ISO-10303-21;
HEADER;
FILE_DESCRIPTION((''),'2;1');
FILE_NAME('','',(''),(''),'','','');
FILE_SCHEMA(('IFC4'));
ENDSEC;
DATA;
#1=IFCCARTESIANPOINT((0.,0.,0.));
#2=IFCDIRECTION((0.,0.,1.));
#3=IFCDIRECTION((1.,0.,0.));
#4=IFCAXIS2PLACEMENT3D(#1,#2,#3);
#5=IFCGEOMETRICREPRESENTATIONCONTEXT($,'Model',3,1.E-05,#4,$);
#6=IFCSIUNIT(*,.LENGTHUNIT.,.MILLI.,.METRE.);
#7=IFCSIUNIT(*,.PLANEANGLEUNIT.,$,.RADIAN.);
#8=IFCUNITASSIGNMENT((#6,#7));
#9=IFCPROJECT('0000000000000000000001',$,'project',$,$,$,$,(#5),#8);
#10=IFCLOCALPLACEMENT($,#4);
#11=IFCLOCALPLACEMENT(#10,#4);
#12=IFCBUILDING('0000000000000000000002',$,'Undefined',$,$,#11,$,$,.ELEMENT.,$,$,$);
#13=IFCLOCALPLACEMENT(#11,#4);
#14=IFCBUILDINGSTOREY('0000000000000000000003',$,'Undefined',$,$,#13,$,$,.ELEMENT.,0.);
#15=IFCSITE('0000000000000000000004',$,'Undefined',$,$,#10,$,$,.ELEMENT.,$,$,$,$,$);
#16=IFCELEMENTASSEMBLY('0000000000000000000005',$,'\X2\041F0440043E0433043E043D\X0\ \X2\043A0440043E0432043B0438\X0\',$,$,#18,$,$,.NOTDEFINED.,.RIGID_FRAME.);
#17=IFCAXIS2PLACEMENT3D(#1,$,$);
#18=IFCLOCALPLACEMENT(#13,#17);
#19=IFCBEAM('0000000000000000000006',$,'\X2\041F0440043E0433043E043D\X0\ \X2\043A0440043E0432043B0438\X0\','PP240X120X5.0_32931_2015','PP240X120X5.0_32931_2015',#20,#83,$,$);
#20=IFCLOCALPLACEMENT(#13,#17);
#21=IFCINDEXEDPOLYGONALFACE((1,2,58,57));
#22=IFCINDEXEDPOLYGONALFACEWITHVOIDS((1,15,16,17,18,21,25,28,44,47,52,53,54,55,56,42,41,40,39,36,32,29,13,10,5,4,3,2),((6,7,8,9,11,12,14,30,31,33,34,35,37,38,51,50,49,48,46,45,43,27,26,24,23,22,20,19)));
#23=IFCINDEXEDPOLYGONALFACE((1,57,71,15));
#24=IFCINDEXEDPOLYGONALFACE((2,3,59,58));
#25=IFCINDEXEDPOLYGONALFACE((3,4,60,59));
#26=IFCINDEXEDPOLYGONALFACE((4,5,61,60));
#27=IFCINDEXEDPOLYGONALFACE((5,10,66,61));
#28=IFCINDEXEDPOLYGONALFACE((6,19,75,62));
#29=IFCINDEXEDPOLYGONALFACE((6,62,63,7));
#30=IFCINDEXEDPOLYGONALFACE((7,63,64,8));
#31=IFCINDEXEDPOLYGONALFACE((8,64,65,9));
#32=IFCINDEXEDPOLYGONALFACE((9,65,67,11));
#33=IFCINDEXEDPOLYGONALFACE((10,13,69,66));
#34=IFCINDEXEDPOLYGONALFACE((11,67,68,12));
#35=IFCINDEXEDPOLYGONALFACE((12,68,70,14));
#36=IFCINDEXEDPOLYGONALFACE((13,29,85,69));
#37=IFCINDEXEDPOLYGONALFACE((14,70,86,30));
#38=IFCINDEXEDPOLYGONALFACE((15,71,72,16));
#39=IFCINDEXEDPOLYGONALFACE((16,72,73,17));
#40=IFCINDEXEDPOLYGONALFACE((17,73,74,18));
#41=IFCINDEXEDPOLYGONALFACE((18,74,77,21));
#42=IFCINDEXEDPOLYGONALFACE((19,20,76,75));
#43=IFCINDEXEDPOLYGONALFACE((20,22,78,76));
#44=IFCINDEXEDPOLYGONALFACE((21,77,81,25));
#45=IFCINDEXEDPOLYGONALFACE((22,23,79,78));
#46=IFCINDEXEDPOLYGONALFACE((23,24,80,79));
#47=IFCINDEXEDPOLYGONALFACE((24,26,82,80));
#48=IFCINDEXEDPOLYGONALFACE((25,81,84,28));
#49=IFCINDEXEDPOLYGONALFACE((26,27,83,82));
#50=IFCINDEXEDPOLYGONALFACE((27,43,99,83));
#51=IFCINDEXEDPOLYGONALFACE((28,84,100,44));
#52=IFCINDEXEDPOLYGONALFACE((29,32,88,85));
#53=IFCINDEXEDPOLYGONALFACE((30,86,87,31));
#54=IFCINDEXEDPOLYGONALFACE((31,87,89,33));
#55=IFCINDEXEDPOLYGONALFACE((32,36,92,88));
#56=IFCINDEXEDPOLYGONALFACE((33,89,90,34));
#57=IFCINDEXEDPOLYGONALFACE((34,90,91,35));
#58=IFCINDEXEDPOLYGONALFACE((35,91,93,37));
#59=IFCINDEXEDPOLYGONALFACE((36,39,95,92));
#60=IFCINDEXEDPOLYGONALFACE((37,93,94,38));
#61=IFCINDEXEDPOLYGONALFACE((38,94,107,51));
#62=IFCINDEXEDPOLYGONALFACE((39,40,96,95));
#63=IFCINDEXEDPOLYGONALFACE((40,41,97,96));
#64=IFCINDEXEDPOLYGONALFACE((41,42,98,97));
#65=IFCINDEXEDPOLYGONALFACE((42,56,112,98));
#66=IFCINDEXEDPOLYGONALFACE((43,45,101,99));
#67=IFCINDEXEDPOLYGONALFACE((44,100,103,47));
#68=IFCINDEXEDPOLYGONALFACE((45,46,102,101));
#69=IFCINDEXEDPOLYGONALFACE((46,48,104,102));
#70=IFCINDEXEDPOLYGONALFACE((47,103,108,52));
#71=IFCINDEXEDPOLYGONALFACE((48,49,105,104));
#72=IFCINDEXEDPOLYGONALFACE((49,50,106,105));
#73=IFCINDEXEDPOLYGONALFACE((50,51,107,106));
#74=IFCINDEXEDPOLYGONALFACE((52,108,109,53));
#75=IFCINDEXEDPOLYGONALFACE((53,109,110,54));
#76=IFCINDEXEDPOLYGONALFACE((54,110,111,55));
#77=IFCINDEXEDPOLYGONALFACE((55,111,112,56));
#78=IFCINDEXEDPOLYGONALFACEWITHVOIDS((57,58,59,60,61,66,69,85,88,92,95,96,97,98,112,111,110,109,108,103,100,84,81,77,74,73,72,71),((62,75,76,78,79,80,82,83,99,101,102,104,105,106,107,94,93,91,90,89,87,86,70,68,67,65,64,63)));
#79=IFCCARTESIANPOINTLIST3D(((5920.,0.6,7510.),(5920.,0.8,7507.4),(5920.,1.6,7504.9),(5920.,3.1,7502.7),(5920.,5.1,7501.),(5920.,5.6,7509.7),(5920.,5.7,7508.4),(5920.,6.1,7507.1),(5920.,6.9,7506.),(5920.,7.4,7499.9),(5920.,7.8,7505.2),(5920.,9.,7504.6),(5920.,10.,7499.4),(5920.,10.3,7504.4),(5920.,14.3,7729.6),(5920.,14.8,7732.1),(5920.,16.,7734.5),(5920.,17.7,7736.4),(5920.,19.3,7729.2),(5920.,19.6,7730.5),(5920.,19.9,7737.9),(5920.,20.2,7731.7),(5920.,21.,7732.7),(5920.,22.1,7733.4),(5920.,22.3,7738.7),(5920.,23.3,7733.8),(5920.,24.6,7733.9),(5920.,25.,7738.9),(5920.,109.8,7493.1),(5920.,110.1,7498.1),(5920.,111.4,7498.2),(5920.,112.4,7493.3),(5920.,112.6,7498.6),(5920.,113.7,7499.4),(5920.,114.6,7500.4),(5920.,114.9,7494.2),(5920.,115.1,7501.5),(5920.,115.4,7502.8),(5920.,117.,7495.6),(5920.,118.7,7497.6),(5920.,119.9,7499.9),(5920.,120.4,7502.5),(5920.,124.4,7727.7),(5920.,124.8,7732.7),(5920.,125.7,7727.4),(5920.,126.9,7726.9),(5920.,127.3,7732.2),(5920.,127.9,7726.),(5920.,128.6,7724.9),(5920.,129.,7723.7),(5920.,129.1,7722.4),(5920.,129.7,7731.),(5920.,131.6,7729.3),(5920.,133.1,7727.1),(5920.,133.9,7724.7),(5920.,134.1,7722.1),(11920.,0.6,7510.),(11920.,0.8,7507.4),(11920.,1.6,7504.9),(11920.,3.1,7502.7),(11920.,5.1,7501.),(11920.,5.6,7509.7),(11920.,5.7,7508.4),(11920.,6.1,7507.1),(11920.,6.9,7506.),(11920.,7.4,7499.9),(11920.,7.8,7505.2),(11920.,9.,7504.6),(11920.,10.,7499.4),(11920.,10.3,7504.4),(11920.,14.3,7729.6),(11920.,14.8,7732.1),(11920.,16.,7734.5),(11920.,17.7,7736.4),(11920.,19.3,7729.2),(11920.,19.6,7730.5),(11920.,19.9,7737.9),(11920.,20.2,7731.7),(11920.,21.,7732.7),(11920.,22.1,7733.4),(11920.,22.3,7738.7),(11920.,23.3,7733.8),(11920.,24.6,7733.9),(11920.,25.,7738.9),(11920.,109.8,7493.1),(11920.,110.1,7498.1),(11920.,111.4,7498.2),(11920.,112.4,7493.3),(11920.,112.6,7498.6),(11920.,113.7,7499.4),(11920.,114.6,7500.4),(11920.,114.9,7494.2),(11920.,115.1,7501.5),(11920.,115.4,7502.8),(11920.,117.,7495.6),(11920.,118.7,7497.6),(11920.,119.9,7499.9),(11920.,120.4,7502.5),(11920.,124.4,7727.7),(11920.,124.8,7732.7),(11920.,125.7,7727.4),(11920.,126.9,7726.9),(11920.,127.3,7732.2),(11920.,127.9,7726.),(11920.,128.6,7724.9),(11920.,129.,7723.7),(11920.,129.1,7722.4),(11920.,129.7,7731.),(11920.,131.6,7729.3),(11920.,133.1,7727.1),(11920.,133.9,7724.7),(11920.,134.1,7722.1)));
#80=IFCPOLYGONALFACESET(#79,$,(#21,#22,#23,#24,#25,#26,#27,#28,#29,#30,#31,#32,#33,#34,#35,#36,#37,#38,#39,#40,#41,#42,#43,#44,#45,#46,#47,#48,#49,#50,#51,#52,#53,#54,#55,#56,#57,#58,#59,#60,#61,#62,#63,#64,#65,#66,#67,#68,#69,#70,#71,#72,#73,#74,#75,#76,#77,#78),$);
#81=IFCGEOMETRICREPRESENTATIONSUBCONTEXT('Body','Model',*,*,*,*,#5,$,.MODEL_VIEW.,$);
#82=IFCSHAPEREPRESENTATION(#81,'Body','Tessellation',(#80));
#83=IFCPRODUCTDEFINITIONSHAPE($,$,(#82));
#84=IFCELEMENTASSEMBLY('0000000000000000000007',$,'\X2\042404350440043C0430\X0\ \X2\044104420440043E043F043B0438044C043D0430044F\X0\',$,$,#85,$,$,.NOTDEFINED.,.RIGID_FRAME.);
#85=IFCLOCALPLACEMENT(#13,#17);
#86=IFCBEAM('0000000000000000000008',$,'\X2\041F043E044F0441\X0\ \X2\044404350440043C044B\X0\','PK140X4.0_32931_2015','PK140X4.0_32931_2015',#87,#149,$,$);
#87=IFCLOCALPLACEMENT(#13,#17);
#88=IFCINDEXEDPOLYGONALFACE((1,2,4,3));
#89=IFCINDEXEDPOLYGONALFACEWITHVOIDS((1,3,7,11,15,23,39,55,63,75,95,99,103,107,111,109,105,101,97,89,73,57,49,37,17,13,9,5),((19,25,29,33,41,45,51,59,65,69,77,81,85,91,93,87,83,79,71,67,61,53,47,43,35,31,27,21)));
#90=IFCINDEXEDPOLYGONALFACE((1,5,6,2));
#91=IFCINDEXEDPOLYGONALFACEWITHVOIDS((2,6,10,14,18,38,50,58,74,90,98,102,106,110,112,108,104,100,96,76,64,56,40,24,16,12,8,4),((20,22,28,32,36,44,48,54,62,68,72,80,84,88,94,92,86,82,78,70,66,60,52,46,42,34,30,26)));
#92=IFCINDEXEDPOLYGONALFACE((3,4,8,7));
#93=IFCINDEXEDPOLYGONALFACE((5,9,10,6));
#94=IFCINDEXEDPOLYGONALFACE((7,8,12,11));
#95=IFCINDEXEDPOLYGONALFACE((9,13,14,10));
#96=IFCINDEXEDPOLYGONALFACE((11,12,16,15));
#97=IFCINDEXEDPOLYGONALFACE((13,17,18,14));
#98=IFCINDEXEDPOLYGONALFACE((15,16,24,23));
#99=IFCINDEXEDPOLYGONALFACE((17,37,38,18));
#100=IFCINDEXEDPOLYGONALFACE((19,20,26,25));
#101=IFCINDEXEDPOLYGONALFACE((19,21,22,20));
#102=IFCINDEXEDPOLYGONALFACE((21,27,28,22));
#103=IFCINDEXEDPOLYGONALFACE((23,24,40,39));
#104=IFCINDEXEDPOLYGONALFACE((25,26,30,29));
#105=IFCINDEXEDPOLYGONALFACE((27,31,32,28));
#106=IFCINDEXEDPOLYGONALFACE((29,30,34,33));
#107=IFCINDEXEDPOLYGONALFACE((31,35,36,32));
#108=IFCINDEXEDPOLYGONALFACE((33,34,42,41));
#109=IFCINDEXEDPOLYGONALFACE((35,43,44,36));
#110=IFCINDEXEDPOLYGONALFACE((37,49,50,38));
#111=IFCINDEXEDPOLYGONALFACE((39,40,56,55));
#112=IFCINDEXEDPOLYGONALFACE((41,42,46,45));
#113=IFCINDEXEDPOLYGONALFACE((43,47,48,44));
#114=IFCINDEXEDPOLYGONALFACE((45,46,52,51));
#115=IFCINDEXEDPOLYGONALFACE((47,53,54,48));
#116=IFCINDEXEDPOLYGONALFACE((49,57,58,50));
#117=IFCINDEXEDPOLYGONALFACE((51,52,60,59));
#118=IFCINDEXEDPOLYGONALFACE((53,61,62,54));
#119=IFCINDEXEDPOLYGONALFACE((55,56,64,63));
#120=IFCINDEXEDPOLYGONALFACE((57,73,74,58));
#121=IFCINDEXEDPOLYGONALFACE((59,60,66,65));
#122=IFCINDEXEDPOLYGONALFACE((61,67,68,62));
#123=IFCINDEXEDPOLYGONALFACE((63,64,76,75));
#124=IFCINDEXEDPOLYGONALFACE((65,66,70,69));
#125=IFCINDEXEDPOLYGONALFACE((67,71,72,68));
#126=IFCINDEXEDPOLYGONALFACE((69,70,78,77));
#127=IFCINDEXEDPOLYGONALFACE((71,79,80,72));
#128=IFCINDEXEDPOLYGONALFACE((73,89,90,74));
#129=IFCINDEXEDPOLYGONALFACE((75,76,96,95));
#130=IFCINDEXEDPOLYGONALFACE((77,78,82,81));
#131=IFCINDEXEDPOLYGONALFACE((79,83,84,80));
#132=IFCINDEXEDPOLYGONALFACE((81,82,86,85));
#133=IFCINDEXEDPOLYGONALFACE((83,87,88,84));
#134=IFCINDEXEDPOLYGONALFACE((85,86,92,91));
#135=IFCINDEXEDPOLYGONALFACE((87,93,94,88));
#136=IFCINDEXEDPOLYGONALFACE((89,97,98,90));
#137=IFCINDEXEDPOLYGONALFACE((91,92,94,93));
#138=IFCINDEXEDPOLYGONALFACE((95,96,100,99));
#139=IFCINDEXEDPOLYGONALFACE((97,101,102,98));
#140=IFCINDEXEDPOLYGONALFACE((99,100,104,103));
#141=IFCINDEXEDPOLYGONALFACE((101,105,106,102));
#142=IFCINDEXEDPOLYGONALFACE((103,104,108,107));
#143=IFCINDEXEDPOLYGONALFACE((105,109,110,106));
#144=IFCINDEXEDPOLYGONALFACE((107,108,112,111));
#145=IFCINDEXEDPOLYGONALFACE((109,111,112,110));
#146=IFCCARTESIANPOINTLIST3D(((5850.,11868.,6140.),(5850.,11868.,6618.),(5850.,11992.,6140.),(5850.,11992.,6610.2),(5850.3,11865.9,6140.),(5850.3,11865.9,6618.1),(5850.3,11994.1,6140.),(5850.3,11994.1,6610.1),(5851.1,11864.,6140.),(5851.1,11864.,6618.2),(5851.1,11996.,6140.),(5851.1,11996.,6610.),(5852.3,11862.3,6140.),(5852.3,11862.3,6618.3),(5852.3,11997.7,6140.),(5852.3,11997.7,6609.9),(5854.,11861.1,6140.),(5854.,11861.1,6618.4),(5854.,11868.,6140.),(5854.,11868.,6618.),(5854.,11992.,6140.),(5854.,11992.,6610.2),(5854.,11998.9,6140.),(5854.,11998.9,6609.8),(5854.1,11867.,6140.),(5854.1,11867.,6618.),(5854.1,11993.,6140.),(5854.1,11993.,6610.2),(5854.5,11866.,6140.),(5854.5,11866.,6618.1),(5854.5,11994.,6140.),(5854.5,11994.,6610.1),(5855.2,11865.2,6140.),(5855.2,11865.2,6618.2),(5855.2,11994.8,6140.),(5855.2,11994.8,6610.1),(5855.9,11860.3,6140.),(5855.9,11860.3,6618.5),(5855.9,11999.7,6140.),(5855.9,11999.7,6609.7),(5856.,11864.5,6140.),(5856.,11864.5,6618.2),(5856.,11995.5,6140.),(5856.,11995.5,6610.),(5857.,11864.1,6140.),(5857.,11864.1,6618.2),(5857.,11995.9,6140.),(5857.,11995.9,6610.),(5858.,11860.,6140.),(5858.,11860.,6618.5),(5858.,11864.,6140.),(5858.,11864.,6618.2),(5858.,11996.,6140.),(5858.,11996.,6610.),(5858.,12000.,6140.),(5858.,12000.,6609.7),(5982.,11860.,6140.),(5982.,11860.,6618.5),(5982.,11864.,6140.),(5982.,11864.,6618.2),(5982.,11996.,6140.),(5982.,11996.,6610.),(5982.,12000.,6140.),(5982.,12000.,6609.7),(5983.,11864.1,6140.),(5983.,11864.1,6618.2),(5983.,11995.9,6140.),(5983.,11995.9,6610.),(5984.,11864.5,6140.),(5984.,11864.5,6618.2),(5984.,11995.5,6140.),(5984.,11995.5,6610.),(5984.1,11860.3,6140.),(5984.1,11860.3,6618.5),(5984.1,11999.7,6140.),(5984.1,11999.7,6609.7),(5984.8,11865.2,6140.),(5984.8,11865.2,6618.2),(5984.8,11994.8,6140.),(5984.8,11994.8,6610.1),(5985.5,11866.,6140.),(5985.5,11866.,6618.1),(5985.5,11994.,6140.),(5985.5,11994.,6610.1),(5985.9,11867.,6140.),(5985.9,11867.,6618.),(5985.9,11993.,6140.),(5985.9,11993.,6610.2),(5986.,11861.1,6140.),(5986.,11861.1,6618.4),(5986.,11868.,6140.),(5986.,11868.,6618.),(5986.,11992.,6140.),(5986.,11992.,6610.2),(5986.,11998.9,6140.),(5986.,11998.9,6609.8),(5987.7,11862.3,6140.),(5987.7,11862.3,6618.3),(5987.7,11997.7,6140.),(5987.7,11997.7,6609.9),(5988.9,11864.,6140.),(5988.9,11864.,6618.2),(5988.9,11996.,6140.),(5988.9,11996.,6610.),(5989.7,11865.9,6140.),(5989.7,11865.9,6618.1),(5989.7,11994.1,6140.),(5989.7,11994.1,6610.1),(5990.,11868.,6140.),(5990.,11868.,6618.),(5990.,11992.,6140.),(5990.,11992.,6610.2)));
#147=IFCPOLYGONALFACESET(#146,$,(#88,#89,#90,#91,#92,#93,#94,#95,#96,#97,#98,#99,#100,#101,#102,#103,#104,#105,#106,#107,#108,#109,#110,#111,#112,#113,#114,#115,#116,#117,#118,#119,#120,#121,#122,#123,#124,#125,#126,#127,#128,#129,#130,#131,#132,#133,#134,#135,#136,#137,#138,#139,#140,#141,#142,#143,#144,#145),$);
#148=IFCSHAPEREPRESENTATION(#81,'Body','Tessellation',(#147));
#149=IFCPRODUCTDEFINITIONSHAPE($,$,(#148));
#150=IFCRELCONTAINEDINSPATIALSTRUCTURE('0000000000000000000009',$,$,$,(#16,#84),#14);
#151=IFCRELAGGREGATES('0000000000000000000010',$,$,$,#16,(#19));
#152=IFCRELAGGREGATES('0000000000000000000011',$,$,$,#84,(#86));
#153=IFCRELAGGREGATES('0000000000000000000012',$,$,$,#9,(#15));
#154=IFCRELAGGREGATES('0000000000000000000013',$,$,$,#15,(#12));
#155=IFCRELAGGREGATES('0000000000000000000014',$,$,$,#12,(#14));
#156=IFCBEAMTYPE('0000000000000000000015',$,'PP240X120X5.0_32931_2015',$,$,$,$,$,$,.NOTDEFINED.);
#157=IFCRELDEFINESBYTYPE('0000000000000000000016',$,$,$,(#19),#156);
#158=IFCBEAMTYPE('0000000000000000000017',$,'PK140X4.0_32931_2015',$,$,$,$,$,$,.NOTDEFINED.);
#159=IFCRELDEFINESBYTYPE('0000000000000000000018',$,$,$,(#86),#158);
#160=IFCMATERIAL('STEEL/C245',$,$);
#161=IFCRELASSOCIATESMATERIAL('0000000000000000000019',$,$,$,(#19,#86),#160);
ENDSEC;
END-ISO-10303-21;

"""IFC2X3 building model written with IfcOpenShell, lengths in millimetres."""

from ifc_helpers import new_model, si_unit, frame, origin_with_axes, origin_2d_with_axis, place, context, subcontext, project, spatial, hollow_rectangle, extrude, clip, halfspace, material, type_object, element, aggregate, save


model = new_model("IFC2X3")

# Units and contexts
model_context = context("Model", 3, precision=1e-05, world=origin_with_axes())
body_context = subcontext(model_context, "Body", "Model", "MODEL_VIEW")
ifc_project = project(units=[si_unit("LENGTHUNIT", "METRE", prefix="MILLI"), si_unit("PLANEANGLEUNIT", "RADIAN")], contexts=[model_context])

# Site, building, storey
site_placement = place(None, origin_with_axes())
site = spatial("IfcSite", under=ifc_project, at=site_placement, Name="Undefined", CompositionType="ELEMENT")
building_placement = place(site_placement, origin_with_axes())
building = spatial("IfcBuilding", under=site, at=building_placement, Name="Undefined", CompositionType="ELEMENT")
storey_placement = place(building_placement, origin_with_axes())
storey = spatial("IfcBuildingStorey", under=building, at=storey_placement, Name="Undefined", CompositionType="ELEMENT", Elevation=0.0)

# Shared definitions
ifc_material = material(Name="STEEL/C245")

# Element assembly, beam
beam_type_1 = type_object("IfcBeamType", Name="PP240X120X5.0_32931_2015", PredefinedType="NOTDEFINED")
assembly_1_placement = place(storey_placement, origin_with_axes())
assembly_1 = element("IfcElementAssembly", 1, at=assembly_1_placement, inside=storey, Name="Прогон кровли", AssemblyPlace="NOTDEFINED", PredefinedType="RIGID_FRAME")
beam_1_placement = place(assembly_1_placement, frame((11920.0, 67.4, 7616.0), z_axis=(0.0, 0.062378, 0.998053), x_axis=(-1.0, 0.0, 0.0)))
beam_1 = element("IfcBeam", 2, at=beam_1_placement, type_object=beam_type_1, material=ifc_material, Name="Прогон кровли", Description="PP240X120X5.0_32931_2015", ObjectType="PP240X120X5.0_32931_2015", context=body_context, shape_type="SweptSolid", body=[
    extrude(hollow_rectangle(XDim=120.0, YDim=240.0, WallThickness=5.0, InnerFilletRadius=5.0, OuterFilletRadius=10.0, at=origin_2d_with_axis()), frame((6000.0, 0.0, 0.0), z_axis=(-1.0, 0.0, 0.0), x_axis=(0.0, -1.0, 0.0)), (0.0, 0.0, 1.0), 6000.0),
])
aggregate(assembly_1, [beam_1])

# Element assembly, beam
assembly_2_placement = place(storey_placement, origin_with_axes())
assembly_2 = element("IfcElementAssembly", 3, at=assembly_2_placement, inside=storey, Name="Ферма строплиьная", AssemblyPlace="NOTDEFINED", PredefinedType="RIGID_FRAME")
beam_type_2 = type_object("IfcBeamType", Name="PK140X4.0_32931_2015", PredefinedType="NOTDEFINED")
beam_2_placement = place(assembly_2_placement, frame((5920.0, 11930.0, 6609.7), z_axis=(1.0, 0.0, 0.0), x_axis=(0.0, 0.0, -1.0)))
beam_2 = element("IfcBeam", 4, at=beam_2_placement, type_object=beam_type_2, material=ifc_material, Name="Пояс фермы", Description="PK140X4.0_32931_2015", ObjectType="PK140X4.0_32931_2015", context=body_context, shape_type="Clipping", body=[
    clip(extrude(hollow_rectangle(XDim=140.0, YDim=140.0, WallThickness=4.0, InnerFilletRadius=4.0, OuterFilletRadius=8.0, at=origin_2d_with_axis()), frame((469.7, 0.0, 0.0), z_axis=(-1.0, 0.0, 0.0), x_axis=(0.0, -1.0, 0.0)), (0.0, 0.0, 1.0), 478.5), halfspace(frame((-14.9, -167.6, 0.0), z_axis=(-0.998053, 0.062378, 0.0), x_axis=(0.0, 0.0, 1.0)), False)),
])
aggregate(assembly_2, [beam_2])

save(model, "model.ifc")
